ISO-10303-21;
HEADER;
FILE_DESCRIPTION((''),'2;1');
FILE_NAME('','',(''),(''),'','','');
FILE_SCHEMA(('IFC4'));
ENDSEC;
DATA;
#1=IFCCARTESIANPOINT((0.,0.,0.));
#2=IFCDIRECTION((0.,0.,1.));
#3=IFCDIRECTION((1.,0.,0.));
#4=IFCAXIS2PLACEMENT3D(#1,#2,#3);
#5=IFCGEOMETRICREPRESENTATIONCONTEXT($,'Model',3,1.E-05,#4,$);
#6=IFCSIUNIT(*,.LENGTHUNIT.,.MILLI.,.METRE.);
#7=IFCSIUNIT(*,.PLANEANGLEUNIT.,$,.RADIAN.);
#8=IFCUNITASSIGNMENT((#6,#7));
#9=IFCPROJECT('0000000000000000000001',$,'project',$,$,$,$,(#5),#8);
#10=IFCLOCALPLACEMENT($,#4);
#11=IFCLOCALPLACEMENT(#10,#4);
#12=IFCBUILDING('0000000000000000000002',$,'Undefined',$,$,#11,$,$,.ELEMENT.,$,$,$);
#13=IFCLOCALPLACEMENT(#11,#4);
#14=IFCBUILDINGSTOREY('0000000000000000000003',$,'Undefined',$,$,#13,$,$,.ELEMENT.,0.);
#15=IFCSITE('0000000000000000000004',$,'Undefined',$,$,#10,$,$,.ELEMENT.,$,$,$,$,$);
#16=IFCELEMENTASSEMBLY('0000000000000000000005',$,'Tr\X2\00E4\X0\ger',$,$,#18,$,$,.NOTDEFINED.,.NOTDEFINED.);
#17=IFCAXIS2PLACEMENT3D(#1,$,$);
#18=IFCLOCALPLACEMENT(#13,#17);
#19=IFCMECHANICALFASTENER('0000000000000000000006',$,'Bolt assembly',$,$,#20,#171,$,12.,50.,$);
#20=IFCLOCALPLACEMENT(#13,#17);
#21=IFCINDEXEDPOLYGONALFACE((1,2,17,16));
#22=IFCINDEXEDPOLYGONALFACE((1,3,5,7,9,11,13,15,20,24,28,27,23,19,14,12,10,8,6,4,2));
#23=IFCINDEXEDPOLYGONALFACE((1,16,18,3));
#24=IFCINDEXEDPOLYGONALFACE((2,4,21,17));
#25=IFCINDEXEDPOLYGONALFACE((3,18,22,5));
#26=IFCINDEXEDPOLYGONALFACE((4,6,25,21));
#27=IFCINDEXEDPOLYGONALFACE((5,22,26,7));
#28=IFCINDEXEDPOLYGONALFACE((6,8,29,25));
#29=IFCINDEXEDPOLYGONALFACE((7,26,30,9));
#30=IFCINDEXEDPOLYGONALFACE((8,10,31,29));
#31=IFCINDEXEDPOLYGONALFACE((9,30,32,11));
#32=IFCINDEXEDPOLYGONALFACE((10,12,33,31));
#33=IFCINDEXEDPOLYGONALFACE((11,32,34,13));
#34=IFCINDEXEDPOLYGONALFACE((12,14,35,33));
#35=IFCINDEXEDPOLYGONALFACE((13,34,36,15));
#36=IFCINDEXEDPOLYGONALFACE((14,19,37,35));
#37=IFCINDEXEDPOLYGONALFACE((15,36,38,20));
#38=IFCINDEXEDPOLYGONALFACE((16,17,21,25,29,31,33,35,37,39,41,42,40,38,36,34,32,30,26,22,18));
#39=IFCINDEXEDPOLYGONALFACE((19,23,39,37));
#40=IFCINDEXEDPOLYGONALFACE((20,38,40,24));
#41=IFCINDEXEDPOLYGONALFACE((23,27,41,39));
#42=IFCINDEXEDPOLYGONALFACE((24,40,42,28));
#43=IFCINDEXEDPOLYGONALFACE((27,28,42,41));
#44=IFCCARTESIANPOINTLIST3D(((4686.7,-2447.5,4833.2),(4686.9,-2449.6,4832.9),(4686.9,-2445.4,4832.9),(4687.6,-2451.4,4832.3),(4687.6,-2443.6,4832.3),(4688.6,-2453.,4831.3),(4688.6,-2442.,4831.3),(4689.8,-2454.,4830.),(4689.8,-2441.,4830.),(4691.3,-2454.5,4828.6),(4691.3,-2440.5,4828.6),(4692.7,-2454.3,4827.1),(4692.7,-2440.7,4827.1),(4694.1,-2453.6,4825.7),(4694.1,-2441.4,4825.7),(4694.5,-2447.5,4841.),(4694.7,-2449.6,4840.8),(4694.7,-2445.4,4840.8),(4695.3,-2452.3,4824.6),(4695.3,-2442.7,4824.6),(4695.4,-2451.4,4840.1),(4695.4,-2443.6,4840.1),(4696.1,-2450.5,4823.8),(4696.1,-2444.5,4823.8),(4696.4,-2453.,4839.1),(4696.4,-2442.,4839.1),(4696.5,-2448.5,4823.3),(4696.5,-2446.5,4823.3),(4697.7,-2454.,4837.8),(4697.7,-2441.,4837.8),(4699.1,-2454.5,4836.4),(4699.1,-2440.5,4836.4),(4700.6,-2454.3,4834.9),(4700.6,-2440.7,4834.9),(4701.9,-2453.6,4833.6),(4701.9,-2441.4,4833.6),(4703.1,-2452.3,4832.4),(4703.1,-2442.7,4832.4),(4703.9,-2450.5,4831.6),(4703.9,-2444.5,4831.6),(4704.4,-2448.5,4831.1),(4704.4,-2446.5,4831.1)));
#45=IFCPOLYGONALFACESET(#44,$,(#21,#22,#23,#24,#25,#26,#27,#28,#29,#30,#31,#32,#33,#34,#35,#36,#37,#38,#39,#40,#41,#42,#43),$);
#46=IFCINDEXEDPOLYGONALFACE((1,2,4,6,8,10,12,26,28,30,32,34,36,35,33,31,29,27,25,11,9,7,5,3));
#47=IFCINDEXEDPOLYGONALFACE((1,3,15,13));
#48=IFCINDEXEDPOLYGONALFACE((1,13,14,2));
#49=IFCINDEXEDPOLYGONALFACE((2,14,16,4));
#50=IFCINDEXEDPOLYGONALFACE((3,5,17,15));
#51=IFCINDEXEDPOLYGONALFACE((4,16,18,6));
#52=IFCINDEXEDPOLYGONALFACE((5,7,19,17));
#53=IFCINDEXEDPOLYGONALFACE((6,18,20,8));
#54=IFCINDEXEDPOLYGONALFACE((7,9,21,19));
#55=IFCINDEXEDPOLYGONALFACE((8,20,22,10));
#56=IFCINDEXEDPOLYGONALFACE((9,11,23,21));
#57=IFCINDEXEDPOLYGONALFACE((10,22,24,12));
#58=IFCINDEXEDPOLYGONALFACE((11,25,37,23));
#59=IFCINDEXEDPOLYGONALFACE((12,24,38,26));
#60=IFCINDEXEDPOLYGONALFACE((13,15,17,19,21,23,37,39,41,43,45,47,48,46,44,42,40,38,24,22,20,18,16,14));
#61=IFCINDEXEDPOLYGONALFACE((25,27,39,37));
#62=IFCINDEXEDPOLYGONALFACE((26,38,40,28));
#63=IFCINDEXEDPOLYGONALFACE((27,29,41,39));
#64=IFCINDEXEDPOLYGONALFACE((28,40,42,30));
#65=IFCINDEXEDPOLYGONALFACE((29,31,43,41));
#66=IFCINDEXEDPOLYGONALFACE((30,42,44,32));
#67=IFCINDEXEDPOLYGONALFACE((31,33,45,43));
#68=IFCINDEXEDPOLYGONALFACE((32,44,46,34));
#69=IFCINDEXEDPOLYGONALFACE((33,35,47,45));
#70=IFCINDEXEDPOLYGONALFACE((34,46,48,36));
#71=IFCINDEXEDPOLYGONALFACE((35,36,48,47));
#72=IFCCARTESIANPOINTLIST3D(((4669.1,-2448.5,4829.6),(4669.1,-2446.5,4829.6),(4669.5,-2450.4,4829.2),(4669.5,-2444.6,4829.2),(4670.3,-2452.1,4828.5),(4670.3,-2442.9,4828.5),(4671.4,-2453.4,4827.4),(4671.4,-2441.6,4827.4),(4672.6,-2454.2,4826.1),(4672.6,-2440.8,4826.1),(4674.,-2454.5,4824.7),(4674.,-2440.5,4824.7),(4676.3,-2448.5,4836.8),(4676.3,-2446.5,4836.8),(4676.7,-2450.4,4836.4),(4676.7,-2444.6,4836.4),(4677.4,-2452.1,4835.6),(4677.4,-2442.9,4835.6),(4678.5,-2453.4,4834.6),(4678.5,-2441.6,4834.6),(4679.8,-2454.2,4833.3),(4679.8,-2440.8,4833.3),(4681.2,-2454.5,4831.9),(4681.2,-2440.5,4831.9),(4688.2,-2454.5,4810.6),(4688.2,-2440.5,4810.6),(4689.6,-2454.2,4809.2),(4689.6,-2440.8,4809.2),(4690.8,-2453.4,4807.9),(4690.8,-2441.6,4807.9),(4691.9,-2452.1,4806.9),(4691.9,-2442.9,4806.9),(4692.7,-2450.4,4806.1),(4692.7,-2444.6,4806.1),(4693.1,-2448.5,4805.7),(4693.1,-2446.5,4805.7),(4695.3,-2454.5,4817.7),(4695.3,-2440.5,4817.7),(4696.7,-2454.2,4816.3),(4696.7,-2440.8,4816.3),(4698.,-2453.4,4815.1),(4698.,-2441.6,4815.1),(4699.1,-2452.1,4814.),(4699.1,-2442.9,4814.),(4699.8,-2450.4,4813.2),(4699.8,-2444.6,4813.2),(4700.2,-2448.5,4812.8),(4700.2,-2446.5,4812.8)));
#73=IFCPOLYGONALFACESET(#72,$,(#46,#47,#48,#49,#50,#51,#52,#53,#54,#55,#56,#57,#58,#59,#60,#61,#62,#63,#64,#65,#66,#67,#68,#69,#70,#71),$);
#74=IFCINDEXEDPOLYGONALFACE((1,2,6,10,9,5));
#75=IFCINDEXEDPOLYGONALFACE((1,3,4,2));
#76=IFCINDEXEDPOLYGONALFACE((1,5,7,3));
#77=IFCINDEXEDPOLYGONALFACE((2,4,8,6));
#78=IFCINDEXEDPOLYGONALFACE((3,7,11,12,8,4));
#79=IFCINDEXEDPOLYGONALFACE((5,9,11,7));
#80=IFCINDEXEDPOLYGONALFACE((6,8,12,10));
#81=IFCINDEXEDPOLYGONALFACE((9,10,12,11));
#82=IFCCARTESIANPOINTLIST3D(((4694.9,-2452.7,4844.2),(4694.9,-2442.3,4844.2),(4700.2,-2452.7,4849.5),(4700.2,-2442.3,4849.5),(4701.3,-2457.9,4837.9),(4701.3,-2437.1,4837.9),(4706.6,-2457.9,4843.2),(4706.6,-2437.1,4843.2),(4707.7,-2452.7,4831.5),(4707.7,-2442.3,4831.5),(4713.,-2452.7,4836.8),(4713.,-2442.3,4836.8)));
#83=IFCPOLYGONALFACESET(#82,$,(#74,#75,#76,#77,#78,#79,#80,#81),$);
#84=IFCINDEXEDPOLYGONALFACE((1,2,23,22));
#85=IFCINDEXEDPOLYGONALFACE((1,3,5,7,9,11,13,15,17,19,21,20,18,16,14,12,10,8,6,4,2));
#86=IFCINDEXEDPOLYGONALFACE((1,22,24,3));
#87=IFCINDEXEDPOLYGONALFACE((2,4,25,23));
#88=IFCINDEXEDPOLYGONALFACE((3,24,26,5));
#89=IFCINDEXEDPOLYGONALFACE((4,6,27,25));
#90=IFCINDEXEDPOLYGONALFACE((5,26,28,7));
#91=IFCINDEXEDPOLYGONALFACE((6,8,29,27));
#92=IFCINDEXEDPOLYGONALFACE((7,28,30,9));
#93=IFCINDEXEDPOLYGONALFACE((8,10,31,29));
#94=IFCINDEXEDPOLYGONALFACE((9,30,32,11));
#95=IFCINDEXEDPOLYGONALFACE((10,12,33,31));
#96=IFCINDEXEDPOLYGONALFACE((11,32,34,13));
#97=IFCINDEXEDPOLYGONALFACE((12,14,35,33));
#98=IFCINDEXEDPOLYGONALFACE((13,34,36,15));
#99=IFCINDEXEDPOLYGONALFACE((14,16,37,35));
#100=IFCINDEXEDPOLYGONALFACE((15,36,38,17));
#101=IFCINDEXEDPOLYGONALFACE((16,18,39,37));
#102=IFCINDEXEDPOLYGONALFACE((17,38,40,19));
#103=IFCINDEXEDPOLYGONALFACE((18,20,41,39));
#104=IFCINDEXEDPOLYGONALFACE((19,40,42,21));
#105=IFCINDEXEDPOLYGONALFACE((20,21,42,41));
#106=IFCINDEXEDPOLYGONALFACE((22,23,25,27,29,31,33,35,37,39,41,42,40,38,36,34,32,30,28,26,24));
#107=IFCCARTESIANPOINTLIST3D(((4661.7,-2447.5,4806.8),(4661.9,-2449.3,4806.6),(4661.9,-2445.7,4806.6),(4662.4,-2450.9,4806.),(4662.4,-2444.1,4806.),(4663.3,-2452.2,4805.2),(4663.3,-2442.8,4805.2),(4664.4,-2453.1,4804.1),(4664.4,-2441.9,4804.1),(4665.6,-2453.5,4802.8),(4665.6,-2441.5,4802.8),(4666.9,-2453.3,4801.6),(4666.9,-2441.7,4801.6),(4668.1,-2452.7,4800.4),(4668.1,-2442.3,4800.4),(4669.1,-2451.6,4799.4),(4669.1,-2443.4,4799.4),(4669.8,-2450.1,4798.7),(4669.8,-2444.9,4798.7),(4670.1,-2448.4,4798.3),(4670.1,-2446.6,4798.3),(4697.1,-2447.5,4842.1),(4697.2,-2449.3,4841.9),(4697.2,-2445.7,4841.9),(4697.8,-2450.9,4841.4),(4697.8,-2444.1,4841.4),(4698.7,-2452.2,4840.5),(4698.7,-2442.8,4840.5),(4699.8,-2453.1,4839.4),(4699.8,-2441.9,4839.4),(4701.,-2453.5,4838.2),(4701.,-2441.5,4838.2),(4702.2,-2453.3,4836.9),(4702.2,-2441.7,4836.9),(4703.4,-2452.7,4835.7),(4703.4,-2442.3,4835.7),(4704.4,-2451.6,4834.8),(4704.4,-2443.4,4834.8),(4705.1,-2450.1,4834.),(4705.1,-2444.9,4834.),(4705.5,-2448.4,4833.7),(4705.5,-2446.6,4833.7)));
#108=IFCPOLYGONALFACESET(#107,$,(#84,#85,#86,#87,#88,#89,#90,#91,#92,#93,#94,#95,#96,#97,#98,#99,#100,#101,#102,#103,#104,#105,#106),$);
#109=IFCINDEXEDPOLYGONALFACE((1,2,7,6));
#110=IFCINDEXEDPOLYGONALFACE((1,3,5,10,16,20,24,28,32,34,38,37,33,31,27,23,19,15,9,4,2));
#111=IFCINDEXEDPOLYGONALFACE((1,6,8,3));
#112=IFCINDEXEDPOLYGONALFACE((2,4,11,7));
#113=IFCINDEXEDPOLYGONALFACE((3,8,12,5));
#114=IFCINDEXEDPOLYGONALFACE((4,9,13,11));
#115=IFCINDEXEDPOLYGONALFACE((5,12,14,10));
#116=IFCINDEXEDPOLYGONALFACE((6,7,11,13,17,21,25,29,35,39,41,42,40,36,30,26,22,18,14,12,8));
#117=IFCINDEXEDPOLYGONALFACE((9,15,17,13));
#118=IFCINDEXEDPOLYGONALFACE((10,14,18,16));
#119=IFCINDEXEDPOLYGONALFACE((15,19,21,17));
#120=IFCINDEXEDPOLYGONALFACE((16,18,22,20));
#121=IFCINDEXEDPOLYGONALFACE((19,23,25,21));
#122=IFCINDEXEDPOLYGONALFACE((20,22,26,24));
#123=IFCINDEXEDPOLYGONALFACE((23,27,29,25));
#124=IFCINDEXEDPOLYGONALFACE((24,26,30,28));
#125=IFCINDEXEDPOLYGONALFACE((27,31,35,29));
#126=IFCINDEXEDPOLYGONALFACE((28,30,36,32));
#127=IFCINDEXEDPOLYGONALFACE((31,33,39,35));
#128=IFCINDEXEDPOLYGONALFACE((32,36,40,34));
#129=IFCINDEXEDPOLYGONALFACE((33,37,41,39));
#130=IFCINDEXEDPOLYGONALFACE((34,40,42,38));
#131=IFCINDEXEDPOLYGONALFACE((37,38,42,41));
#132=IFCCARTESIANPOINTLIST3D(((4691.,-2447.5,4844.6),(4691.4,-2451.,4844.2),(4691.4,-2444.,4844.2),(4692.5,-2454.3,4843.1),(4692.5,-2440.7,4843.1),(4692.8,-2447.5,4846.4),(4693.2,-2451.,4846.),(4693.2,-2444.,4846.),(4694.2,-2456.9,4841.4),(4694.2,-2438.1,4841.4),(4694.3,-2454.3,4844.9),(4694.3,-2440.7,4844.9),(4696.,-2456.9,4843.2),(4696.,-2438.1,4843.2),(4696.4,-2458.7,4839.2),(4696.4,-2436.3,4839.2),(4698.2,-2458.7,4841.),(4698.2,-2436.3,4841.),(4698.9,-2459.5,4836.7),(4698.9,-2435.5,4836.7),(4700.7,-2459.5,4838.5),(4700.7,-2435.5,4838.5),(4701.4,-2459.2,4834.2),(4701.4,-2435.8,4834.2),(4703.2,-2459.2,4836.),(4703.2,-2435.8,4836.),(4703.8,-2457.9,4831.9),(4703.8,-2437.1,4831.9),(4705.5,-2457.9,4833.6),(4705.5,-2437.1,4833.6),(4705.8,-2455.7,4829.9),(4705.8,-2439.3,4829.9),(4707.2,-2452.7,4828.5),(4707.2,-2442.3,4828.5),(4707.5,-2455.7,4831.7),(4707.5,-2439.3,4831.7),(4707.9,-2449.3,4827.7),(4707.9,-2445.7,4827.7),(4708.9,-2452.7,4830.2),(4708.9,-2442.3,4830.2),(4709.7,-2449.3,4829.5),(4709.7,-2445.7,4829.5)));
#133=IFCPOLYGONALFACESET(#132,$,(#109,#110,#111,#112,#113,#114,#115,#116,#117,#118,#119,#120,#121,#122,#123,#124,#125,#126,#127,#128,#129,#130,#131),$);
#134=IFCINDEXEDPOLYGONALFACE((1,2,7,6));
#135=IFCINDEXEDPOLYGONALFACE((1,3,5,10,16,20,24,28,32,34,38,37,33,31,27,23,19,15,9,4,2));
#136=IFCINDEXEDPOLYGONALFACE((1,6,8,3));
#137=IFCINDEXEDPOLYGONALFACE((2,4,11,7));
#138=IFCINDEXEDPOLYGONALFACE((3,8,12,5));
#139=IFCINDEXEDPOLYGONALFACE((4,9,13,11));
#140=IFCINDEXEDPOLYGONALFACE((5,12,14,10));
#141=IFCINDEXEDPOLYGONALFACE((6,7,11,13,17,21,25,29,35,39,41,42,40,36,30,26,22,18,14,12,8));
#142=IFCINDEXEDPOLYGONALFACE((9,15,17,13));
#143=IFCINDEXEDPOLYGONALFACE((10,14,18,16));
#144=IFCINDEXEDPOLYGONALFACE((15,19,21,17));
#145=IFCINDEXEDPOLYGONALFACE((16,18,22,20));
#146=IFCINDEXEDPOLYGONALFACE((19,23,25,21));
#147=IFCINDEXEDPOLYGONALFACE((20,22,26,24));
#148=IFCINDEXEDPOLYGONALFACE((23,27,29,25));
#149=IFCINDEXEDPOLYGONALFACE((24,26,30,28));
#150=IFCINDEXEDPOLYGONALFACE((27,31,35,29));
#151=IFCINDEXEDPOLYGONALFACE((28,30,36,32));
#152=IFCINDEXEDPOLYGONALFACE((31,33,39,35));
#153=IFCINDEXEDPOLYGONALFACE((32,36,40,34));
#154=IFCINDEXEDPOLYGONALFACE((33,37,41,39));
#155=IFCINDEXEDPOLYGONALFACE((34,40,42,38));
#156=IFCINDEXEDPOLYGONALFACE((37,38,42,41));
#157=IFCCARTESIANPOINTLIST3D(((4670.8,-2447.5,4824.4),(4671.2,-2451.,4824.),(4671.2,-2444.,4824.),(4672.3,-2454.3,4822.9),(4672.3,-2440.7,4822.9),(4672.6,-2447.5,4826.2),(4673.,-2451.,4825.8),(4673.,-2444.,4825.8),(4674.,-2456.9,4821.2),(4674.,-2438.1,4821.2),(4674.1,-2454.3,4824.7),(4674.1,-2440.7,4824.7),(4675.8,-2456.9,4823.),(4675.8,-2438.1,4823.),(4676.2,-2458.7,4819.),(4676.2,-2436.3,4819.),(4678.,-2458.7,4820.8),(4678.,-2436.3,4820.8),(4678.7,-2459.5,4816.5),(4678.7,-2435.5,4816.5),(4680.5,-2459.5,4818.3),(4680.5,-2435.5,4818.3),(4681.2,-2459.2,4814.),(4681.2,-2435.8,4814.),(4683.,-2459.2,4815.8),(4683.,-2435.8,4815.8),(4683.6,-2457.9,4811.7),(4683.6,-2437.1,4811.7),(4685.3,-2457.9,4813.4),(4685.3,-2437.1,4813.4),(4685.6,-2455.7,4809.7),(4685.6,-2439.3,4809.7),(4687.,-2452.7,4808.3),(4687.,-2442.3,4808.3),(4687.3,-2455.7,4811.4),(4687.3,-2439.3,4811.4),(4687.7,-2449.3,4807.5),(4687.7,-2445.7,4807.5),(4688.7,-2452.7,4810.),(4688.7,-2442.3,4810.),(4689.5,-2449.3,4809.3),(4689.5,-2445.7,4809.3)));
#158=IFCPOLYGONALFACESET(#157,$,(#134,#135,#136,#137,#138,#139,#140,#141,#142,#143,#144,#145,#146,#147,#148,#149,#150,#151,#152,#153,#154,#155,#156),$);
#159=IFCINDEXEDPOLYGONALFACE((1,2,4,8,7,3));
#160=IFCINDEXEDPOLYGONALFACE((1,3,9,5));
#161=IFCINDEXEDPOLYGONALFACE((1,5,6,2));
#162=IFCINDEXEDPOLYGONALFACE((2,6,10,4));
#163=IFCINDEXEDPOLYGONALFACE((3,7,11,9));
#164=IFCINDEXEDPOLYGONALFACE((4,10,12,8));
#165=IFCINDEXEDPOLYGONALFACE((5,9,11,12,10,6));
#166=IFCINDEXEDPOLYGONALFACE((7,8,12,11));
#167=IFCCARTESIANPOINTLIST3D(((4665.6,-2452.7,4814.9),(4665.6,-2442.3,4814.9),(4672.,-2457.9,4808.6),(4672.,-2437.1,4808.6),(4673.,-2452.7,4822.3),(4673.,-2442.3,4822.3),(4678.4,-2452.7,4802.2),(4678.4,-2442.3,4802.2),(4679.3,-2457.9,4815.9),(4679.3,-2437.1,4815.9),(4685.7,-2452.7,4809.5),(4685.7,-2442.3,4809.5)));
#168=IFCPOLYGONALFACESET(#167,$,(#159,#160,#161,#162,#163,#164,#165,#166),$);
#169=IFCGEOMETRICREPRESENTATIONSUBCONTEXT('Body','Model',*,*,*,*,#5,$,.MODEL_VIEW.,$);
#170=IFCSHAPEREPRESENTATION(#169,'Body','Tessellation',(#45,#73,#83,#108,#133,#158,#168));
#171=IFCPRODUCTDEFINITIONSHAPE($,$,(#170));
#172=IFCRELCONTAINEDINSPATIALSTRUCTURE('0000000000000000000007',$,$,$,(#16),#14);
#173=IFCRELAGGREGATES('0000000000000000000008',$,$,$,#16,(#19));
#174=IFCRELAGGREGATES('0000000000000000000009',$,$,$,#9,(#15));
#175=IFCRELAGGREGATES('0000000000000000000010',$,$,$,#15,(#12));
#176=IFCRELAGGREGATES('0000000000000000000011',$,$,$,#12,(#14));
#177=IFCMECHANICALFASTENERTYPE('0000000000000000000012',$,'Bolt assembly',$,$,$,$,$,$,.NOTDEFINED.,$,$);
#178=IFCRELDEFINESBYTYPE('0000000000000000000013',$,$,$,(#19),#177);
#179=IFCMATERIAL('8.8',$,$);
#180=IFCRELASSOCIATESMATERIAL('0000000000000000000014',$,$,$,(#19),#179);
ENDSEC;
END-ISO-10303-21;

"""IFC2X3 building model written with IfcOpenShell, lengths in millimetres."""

from ifc_helpers import new_model, si_unit, frame, frame_2d, origin_with_axes, origin_2d_with_axis, place, context, subcontext, project, spatial, polyline, circle_curve, parameter, trimmed, segment, composite_curve, circle, outline, extrude, source, transform, mapped, material, type_object, element, aggregate, save


model = new_model("IFC2X3")

# Units and contexts
model_context = context("Model", 3, precision=1e-05, world=origin_with_axes())
body_context = subcontext(model_context, "Body", "Model", "MODEL_VIEW")
ifc_project = project(units=[si_unit("LENGTHUNIT", "METRE", prefix="MILLI"), si_unit("PLANEANGLEUNIT", "RADIAN")], contexts=[model_context])

# Site, building, storey
site_placement = place(None, origin_with_axes())
site = spatial("IfcSite", under=ifc_project, at=site_placement, Name="Undefined", CompositionType="ELEMENT")
building_placement = place(site_placement, origin_with_axes())
building = spatial("IfcBuilding", under=site, at=building_placement, Name="Undefined", CompositionType="ELEMENT")
storey_placement = place(building_placement, origin_with_axes())
storey = spatial("IfcBuildingStorey", under=building, at=storey_placement, Name="Undefined", CompositionType="ELEMENT", Elevation=0.0)

# Element assembly, mechanical fastener
assembly_placement = place(storey_placement, origin_with_axes())
assembly = element("IfcElementAssembly", 1, at=assembly_placement, inside=storey, Name="Träger", AssemblyPlace="NOTDEFINED", PredefinedType="NOTDEFINED")
ifc_material_1 = material(Name="8.8")
mechanical_fastener_type = type_object("IfcMechanicalFastenerType", Name="Bolt assembly")
shared_shape_1 = source(origin_with_axes(), body_context, "Body", "SweptSolid", [
    extrude(circle(Radius=7.0, at=origin_2d_with_axis()), frame((0.0, -26.0, 0.0), z_axis=(0.0, 1.0, 0.0), x_axis=(1.0, 0.0, 0.0)), (0.0, 0.0, 1.0), 11.1),
    extrude(outline(composite_curve([segment(polyline([(-10.0, 7.0), (10.0, 7.0)]), True, "CONTINUOUS"), segment(trimmed(circle_curve(frame_2d((10.0, 0.0), x_axis=(0.0, 1.0)), 7.0), [parameter(0.0)], [parameter(3.141593)], False, "PARAMETER"), True, "CONTINUOUS"), segment(polyline([(10.0, -7.0), (-10.0, -7.0)]), True, "CONTINUOUS"), segment(trimmed(circle_curve(frame_2d((-10.0, 0.0), x_axis=(0.0, -1.0)), 7.0), [parameter(0.0)], [parameter(3.141593)], False, "PARAMETER"), True, "DISCONTINUOUS")], self_intersect=False)), frame((0.0, -10.1, 0.0), z_axis=(0.0, 1.0, 0.0), x_axis=(1.0, 0.0, 0.0)), (0.0, 0.0, 1.0), 10.1),
    extrude(outline(polyline([(9.0, -5.2), (9.0, 5.2), (0.0, 10.4), (-9.0, 5.2), (-9.0, -5.2), (0.0, -10.4), (9.0, -5.2)])), frame((0.0, -36.1, 0.0), z_axis=(0.0, 1.0, 0.0), x_axis=(1.0, 0.0, 0.0)), (0.0, 0.0, 1.0), 7.5),
    extrude(circle(Radius=6.0, at=origin_2d_with_axis()), frame((0.0, -28.6, 0.0), z_axis=(0.0, 1.0, 0.0), x_axis=(1.0, 0.0, 0.0)), (0.0, 0.0, 1.0), 50.0),
    extrude(circle(Radius=12.0, at=origin_2d_with_axis()), frame((0.0, -28.6, 0.0), z_axis=(0.0, 1.0, 0.0), x_axis=(1.0, 0.0, 0.0)), (0.0, 0.0, 1.0), 2.5),
    extrude(circle(Radius=12.0, at=origin_2d_with_axis()), frame((0.0, 0.0, 0.0), z_axis=(0.0, 1.0, 0.0), x_axis=(1.0, 0.0, 0.0)), (0.0, 0.0, 1.0), 2.5),
    extrude(outline(polyline([(9.0, -5.2), (9.0, 5.2), (0.0, 10.4), (-9.0, 5.2), (-9.0, -5.2), (0.0, -10.4), (9.0, -5.2)])), frame((0.0, 2.5, 0.0), z_axis=(0.0, 1.0, 0.0), x_axis=(1.0, 0.0, 0.0)), (0.0, 0.0, 1.0), 10.4),
])
mechanical_fastener_1_placement = place(assembly_placement, frame((4681.1, -2447.5, 4817.7), z_axis=(0.0, -1.0, 0.0), x_axis=(-0.707107, 0.0, 0.707107)))
mechanical_fastener_1 = element("IfcMechanicalFastener", 2, at=mechanical_fastener_1_placement, type_object=mechanical_fastener_type, material=ifc_material_1, Name="Bolt assembly", NominalDiameter=12.0, NominalLength=50.0, context=body_context, shape_type="MappedRepresentation", body=[
    mapped(shared_shape_1, transform((0.0, 0.0, 0.0))),
])
aggregate(assembly, [mechanical_fastener_1])

save(model, "model.ifc")
